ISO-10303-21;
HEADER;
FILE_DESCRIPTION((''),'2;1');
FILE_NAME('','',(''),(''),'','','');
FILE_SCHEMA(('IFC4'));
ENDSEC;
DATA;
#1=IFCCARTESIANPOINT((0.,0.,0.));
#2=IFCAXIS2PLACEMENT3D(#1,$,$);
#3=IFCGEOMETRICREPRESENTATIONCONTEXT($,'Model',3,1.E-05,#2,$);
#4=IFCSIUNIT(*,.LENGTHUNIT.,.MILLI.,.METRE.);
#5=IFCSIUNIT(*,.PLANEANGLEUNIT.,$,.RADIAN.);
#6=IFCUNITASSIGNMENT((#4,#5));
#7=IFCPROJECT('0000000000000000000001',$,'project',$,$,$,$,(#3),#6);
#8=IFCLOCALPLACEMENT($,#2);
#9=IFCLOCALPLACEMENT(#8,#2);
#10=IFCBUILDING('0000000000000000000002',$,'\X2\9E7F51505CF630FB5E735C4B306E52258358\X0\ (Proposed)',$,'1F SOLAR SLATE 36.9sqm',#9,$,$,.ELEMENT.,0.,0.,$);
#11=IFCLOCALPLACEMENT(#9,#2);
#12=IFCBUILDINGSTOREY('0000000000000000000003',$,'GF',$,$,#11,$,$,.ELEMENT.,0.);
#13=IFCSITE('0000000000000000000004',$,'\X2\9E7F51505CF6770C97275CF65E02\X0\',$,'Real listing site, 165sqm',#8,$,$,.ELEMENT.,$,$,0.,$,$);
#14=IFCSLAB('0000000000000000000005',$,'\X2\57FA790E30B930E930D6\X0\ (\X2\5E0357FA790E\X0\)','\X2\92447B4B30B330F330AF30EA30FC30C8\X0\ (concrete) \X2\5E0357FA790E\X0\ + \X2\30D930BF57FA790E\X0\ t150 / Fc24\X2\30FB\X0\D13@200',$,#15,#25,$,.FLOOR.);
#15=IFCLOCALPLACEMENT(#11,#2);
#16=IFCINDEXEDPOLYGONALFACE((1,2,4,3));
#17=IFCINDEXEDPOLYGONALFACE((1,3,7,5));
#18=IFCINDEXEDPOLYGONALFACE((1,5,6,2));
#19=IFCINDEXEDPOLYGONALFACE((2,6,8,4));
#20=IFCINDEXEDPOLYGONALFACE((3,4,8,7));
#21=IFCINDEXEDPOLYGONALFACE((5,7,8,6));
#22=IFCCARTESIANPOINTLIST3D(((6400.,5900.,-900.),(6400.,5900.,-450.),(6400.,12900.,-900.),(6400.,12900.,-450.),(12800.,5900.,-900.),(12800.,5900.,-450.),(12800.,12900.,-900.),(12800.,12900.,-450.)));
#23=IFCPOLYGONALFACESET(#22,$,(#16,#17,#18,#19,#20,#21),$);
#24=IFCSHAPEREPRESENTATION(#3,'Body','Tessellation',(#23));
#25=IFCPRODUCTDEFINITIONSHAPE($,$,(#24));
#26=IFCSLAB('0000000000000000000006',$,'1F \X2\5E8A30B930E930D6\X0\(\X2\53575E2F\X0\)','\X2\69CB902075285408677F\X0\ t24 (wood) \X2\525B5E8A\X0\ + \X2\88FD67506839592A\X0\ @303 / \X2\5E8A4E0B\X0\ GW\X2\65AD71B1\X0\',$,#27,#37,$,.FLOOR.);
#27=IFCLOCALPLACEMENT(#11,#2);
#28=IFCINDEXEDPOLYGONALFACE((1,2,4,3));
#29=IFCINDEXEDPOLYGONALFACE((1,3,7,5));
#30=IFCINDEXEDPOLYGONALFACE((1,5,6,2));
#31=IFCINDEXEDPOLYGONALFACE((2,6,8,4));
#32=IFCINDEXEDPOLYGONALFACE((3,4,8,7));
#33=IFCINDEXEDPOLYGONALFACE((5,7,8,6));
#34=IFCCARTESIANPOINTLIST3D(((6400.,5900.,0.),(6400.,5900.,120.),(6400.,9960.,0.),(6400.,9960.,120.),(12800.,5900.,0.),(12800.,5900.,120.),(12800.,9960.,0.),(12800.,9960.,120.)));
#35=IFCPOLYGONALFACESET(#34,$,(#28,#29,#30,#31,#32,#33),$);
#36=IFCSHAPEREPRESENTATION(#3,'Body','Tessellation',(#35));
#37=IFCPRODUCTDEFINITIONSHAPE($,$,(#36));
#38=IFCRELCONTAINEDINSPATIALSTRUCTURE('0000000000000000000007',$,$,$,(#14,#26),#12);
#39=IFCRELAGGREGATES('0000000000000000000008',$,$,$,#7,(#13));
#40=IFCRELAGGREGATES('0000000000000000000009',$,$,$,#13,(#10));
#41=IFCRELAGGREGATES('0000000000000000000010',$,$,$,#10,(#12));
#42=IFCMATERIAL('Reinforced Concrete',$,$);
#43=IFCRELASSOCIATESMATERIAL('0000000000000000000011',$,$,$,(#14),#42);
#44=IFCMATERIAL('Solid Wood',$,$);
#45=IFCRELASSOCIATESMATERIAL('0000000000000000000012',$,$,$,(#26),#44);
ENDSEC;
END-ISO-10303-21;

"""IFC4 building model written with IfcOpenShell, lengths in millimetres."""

from ifc_helpers import new_model, si_unit, frame, frame_2d, origin, place, context, project, spatial, rectangle, extrude, material, element, save


model = new_model("IFC4")

# Units and contexts
model_context = context("Model", 3, precision=1e-05, world=origin())
ifc_project = project(units=[si_unit("LENGTHUNIT", "METRE", prefix="MILLI"), si_unit("PLANEANGLEUNIT", "RADIAN")], contexts=[model_context])

# Site, building, storey
site_placement = place(None, origin())
site = spatial("IfcSite", under=ifc_project, at=site_placement, Name="鹿児島県霧島市", ObjectType="Real listing site, 165sqm", CompositionType="ELEMENT", RefElevation=0.0)
building_placement = place(site_placement, origin())
building = spatial("IfcBuilding", under=site, at=building_placement, Name="鹿児島・平屋の別荘 (Proposed)", ObjectType="1F SOLAR SLATE 36.9sqm", CompositionType="ELEMENT", ElevationOfRefHeight=0.0, ElevationOfTerrain=0.0)
storey_placement = place(building_placement, origin())
storey = spatial("IfcBuildingStorey", under=building, at=storey_placement, Name="GF", CompositionType="ELEMENT", Elevation=0.0)

# Shared definitions
ifc_material_1 = material(Name="Solid Wood")

# Slabs
ifc_material_2 = material(Name="Reinforced Concrete")
slab_1_placement = place(storey_placement, frame((3200.0, 2950.0, -450.0)))
element("IfcSlab", 1, at=slab_1_placement, inside=storey, material=ifc_material_2, Name="基礎スラブ (布基礎)", Description="鉄筋コンクリート (concrete) 布基礎 + ベタ基礎 t150 / Fc24・D13@200", PredefinedType="FLOOR", context=model_context, shape_type="SweptSolid", body=[
    extrude(rectangle(XDim=6400.0, YDim=7000.0, at=frame_2d((3200.0, 3500.0))), frame((3200.0, 2950.0, -450.0)), (0.0, 0.0, 1.0), 450.0),
])
slab_2_placement = place(storey_placement, frame((3200.0, 2950.0, 0.0)))
element("IfcSlab", 2, at=slab_2_placement, inside=storey, material=ifc_material_1, Name="1F 床スラブ(南帯)", Description="構造用合板 t24 (wood) 剛床 + 製材根太 @303 / 床下 GW断熱", PredefinedType="FLOOR", context=model_context, shape_type="SweptSolid", body=[
    extrude(rectangle(XDim=6400.0, YDim=4060.0, at=frame_2d((3200.0, 2030.0))), frame((3200.0, 2950.0, 0.0)), (0.0, 0.0, 1.0), 120.0),
])

save(model, "model.ifc")
